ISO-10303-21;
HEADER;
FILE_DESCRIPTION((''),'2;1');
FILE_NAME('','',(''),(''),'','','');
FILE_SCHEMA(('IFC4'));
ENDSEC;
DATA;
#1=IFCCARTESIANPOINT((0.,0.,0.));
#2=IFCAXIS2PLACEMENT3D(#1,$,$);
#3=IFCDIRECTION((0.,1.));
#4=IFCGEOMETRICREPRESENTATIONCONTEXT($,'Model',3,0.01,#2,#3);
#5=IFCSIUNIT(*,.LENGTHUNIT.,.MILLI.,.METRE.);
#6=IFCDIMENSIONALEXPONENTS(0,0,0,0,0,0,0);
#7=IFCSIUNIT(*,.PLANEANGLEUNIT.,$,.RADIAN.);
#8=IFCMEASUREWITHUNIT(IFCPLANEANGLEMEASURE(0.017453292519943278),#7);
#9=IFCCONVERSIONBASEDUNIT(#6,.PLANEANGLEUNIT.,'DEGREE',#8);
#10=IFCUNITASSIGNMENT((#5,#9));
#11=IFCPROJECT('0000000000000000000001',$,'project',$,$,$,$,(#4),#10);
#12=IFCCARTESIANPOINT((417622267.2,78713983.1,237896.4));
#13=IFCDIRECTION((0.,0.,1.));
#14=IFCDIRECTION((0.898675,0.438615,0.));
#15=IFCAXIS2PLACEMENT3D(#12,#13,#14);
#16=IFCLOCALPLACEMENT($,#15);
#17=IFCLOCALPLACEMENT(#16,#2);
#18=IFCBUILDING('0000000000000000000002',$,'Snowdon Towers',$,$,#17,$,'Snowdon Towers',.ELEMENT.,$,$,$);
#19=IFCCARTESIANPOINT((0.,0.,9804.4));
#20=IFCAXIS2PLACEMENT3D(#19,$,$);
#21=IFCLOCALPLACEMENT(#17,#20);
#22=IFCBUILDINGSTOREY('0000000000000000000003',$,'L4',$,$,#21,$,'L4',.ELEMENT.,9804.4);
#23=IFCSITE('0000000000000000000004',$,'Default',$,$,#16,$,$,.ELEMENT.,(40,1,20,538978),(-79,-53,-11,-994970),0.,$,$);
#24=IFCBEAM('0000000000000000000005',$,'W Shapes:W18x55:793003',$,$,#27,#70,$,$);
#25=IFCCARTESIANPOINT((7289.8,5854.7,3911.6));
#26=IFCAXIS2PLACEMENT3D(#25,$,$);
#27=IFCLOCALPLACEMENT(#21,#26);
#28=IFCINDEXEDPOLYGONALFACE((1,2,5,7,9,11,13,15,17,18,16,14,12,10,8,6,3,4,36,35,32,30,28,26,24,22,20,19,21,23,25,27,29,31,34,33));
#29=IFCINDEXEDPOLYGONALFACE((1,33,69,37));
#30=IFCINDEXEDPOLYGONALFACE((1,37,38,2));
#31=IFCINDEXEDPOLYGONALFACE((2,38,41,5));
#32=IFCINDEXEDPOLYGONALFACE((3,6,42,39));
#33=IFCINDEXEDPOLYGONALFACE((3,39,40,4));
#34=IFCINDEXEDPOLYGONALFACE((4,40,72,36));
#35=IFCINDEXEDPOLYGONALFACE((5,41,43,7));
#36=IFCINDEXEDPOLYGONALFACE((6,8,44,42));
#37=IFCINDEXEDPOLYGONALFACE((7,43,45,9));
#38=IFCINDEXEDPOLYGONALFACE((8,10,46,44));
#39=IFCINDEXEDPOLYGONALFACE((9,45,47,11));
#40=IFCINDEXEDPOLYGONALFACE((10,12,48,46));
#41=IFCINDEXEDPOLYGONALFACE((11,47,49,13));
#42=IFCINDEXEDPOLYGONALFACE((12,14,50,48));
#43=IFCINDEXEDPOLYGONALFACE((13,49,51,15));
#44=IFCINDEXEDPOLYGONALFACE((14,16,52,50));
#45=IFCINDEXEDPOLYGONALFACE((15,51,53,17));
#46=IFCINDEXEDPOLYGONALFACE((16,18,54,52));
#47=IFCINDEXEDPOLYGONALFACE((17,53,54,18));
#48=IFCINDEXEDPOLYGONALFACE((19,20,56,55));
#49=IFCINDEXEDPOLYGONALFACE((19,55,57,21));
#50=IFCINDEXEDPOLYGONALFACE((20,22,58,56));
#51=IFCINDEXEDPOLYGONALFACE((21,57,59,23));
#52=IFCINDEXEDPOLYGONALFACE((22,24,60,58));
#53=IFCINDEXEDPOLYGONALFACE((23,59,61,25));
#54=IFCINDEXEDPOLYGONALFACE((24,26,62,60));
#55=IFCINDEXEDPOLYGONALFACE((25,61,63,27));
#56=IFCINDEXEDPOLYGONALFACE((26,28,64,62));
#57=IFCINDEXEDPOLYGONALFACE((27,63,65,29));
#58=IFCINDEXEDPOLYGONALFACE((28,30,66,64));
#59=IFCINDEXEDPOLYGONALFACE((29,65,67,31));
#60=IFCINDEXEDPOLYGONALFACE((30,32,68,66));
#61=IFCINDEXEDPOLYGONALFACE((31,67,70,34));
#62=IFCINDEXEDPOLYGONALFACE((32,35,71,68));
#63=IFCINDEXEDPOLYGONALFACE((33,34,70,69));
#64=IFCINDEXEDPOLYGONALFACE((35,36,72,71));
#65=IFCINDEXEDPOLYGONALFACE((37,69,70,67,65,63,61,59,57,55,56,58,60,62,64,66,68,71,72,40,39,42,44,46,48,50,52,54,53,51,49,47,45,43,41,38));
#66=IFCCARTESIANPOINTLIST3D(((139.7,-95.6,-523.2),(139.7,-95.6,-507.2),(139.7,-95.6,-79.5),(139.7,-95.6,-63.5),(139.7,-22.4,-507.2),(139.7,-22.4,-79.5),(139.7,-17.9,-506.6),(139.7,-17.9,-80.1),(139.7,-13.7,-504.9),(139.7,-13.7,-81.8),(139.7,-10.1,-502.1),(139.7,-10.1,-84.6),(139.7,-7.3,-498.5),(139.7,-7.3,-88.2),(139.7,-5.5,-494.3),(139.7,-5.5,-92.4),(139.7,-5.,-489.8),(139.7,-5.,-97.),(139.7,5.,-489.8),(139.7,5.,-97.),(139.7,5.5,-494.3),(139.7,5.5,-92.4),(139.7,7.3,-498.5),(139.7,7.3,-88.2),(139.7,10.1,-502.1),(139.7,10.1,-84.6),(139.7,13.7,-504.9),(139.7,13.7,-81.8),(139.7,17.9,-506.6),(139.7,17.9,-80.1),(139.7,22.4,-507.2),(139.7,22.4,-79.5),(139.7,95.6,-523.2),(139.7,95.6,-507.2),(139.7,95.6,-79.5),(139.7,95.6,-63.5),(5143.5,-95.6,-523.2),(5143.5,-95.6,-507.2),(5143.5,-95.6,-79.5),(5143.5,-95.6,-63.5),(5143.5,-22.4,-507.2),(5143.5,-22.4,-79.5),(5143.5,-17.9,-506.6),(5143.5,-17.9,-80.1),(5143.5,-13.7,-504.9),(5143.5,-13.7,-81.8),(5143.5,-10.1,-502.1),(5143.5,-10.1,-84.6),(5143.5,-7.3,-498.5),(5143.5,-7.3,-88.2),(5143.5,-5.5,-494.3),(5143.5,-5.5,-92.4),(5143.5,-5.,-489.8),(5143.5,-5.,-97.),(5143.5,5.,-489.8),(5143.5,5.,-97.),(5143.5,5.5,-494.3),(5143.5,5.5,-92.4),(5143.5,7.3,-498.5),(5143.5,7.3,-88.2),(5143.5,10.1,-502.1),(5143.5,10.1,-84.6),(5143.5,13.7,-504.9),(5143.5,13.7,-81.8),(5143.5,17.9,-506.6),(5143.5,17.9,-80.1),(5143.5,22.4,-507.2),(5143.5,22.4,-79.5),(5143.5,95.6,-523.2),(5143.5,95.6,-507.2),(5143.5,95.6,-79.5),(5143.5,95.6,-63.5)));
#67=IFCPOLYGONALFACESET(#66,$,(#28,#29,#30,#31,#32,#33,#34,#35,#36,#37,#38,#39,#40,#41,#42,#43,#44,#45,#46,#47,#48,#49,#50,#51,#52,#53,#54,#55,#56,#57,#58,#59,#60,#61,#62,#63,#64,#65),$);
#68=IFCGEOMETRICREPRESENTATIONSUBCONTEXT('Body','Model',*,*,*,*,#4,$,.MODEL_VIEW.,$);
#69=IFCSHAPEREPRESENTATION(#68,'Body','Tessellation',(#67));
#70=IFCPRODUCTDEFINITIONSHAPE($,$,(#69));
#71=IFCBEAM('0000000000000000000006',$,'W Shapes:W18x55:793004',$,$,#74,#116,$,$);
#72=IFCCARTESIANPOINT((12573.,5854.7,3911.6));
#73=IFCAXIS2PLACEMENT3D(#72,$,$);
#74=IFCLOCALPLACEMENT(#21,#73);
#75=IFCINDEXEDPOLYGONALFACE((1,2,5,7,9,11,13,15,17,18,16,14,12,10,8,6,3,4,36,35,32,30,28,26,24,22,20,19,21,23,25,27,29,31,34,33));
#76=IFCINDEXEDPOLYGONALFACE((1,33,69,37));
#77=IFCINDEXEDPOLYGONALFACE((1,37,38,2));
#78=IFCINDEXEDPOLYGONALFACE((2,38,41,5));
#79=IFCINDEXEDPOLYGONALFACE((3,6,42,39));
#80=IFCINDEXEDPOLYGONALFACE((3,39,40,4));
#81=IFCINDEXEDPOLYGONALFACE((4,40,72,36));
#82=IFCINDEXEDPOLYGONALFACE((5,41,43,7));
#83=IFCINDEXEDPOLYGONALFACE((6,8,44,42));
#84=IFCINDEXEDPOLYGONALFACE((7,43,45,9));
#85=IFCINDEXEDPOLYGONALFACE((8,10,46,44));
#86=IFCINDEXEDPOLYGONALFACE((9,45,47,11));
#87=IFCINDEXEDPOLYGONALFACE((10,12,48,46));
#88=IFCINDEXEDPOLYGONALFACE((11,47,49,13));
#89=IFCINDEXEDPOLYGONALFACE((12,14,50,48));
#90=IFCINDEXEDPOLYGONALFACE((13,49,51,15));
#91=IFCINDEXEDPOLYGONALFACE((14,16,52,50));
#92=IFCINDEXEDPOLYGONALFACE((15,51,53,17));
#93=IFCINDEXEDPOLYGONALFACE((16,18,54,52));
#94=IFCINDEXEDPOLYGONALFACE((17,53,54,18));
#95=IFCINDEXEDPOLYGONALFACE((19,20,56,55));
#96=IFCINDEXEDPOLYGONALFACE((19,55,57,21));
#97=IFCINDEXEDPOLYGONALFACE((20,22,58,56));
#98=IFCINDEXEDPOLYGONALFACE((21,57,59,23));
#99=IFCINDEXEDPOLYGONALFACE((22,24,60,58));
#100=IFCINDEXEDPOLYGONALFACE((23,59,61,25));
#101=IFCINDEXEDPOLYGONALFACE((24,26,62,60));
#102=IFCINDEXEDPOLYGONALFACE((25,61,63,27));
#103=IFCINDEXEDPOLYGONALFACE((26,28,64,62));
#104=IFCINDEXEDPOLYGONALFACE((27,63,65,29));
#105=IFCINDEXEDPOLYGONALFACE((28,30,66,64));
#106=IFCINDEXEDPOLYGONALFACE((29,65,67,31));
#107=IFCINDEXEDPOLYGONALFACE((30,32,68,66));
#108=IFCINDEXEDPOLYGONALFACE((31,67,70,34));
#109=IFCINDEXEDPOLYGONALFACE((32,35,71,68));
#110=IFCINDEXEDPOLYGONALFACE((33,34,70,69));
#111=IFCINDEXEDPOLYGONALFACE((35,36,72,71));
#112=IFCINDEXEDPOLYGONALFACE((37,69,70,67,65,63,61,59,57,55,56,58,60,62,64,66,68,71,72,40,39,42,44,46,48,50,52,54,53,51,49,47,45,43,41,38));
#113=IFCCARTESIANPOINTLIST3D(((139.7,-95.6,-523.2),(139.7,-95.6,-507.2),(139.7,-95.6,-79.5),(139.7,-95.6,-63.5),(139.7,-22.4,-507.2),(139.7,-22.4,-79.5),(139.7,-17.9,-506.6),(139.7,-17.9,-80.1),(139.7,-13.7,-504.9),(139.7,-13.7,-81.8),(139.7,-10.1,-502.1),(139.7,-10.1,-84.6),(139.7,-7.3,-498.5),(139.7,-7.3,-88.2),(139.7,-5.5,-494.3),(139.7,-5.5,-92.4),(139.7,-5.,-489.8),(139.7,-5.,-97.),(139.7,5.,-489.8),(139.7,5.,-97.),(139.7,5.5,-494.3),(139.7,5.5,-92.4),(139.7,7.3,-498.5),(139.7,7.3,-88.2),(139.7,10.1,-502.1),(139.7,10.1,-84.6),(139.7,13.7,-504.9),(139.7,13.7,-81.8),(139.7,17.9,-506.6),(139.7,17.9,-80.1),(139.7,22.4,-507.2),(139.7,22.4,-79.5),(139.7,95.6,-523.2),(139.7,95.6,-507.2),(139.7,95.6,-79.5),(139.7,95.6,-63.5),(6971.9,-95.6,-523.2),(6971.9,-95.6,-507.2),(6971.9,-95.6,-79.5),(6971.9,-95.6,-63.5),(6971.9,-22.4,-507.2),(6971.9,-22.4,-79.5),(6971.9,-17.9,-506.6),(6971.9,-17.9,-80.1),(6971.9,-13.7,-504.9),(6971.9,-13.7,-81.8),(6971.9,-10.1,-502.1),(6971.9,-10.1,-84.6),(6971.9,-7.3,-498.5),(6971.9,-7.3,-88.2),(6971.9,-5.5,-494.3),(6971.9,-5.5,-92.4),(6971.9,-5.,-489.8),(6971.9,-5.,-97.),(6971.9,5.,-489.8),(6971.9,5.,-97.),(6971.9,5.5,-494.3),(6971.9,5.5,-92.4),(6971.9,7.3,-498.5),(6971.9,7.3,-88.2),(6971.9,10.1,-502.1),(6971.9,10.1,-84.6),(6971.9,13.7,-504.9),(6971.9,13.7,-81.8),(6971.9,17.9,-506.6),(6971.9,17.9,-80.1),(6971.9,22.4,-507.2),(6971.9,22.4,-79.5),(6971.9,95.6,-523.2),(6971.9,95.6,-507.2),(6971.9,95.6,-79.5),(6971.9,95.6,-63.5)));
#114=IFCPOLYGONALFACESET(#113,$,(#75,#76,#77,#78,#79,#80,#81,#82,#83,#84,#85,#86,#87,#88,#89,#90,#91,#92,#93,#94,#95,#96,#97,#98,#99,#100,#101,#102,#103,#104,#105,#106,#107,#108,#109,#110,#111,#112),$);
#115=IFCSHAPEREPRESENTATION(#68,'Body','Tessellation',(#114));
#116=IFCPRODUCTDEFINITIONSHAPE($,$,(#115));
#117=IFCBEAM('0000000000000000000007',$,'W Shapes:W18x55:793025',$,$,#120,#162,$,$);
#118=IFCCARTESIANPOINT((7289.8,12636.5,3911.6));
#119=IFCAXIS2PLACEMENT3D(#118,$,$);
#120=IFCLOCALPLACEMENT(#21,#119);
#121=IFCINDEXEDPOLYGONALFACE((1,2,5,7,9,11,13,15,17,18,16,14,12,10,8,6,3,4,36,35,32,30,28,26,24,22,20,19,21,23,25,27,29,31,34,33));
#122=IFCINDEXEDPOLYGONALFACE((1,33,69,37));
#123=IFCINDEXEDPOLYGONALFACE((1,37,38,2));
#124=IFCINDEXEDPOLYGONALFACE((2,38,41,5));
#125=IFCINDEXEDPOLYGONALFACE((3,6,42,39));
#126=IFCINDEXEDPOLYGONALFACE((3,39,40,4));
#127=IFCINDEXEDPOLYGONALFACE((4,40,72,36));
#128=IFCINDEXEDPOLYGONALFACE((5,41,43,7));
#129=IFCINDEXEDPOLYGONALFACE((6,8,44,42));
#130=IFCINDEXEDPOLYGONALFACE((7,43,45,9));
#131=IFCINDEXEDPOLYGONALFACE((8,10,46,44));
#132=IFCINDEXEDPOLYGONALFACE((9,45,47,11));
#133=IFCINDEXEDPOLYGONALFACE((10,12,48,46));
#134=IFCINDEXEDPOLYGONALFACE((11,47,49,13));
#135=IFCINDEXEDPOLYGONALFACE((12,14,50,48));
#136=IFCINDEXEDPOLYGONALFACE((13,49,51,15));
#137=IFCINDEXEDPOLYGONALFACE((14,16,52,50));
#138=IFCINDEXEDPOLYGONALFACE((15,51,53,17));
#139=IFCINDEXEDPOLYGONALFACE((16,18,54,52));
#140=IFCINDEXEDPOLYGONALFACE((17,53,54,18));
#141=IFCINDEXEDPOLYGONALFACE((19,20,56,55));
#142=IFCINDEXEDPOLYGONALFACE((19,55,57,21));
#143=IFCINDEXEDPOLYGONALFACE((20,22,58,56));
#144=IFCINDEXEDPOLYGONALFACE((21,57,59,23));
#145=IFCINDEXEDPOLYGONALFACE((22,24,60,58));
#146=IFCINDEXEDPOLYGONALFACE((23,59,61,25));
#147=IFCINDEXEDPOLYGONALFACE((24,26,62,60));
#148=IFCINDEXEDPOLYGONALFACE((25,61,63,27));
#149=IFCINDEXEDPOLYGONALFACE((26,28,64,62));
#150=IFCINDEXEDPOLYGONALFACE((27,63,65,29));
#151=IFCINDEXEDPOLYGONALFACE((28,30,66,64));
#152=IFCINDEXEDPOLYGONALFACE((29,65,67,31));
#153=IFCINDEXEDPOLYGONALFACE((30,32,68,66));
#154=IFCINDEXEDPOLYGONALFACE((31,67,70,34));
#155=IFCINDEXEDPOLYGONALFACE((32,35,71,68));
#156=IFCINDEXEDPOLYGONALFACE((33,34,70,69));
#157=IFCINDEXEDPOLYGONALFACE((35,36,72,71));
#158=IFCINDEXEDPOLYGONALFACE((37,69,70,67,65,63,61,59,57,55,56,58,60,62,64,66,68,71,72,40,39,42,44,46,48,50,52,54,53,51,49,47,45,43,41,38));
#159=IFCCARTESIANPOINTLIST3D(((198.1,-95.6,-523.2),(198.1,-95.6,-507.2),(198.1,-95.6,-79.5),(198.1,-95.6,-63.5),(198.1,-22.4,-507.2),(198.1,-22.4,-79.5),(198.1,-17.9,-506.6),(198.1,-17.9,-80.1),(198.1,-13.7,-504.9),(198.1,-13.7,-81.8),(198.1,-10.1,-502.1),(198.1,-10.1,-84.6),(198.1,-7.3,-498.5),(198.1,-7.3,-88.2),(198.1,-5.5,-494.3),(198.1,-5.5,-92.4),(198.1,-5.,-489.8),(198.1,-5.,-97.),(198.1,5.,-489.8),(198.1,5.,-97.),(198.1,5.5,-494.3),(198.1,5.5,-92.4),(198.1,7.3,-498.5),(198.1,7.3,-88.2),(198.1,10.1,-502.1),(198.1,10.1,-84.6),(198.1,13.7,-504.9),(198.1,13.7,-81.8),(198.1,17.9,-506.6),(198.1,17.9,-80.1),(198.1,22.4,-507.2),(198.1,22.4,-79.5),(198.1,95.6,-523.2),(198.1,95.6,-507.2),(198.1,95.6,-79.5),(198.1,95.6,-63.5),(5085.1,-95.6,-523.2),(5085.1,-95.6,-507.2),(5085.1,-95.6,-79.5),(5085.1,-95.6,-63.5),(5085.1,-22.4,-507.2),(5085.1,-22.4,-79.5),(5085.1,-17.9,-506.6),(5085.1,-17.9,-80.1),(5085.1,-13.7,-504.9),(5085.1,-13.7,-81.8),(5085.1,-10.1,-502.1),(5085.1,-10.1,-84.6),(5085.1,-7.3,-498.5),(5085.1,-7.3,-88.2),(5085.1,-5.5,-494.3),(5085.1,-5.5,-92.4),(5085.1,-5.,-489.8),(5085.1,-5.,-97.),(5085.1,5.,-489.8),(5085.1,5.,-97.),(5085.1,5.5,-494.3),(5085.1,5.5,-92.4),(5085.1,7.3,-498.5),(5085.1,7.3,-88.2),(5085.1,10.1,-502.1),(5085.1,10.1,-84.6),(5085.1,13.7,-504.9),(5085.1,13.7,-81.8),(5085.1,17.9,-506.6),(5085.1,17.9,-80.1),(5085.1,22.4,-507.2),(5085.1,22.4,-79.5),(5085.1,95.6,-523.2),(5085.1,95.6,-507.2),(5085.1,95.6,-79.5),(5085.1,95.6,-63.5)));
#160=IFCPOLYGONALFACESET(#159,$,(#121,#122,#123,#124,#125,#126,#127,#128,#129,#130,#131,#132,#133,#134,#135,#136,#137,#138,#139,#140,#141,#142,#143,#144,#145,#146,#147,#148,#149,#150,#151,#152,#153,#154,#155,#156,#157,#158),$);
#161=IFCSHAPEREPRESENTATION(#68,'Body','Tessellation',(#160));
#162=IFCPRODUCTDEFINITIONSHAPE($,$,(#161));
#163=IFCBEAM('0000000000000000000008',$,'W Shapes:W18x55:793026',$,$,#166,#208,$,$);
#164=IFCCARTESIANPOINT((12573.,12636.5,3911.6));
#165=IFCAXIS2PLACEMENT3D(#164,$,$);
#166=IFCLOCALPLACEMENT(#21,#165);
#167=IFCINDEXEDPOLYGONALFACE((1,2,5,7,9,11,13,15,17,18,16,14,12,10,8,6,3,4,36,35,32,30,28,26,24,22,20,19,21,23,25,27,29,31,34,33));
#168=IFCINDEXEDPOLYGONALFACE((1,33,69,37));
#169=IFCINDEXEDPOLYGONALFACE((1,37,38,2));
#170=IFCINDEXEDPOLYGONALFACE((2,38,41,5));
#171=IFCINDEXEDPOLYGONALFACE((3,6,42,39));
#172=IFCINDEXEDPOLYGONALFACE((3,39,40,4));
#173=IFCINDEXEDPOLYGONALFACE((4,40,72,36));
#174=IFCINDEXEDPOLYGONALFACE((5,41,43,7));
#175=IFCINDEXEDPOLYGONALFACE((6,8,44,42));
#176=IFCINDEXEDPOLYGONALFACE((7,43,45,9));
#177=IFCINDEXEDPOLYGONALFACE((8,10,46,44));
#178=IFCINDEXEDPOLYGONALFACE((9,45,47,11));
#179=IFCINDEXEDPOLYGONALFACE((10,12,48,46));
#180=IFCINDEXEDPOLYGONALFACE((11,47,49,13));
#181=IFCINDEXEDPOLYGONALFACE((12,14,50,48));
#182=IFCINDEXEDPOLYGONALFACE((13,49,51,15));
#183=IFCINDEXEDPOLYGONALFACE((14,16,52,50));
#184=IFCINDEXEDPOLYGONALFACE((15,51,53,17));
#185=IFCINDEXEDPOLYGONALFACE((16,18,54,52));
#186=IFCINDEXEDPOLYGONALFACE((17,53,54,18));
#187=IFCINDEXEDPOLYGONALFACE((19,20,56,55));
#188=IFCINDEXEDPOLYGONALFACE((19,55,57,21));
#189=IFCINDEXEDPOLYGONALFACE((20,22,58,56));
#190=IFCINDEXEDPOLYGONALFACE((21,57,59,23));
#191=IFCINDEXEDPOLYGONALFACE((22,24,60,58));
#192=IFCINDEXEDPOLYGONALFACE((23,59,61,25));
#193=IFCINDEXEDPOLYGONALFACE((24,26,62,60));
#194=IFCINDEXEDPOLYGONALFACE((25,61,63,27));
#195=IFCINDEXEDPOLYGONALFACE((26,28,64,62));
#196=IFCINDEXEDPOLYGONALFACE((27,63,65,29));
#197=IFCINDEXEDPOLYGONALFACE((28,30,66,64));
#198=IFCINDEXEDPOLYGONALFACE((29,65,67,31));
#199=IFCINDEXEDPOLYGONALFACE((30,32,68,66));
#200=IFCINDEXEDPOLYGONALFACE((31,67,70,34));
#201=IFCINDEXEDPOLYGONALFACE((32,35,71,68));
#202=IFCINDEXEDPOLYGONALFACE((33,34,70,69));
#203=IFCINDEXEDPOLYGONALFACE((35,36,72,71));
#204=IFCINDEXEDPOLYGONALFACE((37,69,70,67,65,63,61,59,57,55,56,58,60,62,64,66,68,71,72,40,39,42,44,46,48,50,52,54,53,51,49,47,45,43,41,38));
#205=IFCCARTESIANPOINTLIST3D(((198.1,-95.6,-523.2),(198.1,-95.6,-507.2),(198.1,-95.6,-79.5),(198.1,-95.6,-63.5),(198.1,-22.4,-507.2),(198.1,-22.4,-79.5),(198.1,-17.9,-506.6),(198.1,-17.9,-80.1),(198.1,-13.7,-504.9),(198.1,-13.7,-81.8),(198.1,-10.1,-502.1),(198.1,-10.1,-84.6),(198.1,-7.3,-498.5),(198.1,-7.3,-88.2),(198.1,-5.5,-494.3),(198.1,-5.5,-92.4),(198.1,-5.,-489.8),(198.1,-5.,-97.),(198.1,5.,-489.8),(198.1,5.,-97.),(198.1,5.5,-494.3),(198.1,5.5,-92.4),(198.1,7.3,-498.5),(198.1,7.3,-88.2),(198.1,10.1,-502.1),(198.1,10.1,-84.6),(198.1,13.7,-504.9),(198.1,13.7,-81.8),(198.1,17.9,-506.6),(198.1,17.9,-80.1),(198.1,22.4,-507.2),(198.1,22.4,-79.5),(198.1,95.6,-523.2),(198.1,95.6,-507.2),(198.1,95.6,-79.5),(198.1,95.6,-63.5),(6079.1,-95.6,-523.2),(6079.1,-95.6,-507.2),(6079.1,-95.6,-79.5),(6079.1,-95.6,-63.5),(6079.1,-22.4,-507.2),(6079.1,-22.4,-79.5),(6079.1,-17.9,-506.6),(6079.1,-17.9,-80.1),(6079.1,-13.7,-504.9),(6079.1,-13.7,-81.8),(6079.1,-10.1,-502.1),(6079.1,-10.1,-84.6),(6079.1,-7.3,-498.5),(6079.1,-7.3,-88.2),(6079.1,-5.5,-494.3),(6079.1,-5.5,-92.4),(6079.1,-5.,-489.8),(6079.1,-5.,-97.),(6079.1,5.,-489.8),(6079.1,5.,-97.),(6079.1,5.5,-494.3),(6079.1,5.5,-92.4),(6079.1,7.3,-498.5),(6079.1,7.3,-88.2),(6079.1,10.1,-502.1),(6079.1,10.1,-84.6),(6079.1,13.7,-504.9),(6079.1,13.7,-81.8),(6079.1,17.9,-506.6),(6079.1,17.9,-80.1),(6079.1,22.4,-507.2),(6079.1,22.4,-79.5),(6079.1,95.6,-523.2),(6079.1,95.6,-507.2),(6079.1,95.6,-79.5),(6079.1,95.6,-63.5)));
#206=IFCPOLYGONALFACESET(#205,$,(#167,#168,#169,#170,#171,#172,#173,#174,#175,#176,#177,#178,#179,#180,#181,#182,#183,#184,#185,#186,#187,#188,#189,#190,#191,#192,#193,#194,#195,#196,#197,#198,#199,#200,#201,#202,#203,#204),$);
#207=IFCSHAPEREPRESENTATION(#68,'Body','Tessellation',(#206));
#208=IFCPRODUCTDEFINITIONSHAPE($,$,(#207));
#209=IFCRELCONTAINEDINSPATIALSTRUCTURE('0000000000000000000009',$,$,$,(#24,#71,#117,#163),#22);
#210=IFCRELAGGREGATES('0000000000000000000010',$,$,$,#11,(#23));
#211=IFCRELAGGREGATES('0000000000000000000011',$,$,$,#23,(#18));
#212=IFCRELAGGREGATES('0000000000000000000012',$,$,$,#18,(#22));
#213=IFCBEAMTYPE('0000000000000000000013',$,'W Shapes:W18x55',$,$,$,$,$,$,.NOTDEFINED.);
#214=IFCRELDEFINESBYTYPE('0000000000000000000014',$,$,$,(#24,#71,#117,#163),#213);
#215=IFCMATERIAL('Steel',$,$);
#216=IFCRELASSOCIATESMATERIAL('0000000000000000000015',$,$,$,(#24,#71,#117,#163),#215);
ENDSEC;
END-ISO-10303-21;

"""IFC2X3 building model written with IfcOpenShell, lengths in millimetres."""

from ifc_helpers import new_model, entity, si_unit, converted_unit, direction, frame, frame_2d, origin, place, context, subcontext, project, spatial, i_section, extrude, material, type_object, element, save


model = new_model("IFC2X3")

# Units and contexts
model_context = context("Model", 3, precision=0.01, world=origin(), true_north=direction((0.0, 1.0)))
body_context = subcontext(model_context, "Body", "Model", "MODEL_VIEW")
ifc_project = project(units=[si_unit("LENGTHUNIT", "METRE", prefix="MILLI"), converted_unit("PLANEANGLEUNIT", "DEGREE", entity("IfcPlaneAngleMeasure", 0.017453292519943278), si_unit("PLANEANGLEUNIT", "RADIAN"), dimensions=[0, 0, 0, 0, 0, 0, 0])], contexts=[model_context])

# Site, building, storey
site_placement = place(None, frame((417622267.2, 78713983.1, 237896.4), z_axis=(0.0, 0.0, 1.0), x_axis=(0.898675, 0.438615, 0.0)))
site = spatial("IfcSite", under=ifc_project, at=site_placement, Name="Default", CompositionType="ELEMENT", RefLatitude=(40, 1, 20, 538978), RefLongitude=(-79, -53, -11, -994970), RefElevation=0.0)
building_placement = place(site_placement, origin())
building = spatial("IfcBuilding", under=site, at=building_placement, Name="Snowdon Towers", LongName="Snowdon Towers", CompositionType="ELEMENT")
storey_placement = place(building_placement, frame((0.0, 0.0, 9804.4)))
storey = spatial("IfcBuildingStorey", under=building, at=storey_placement, Name="L4", LongName="L4", CompositionType="ELEMENT", Elevation=9804.4)

# Shared definitions
ifc_material_1 = material(Name="Steel")

# Beams
beam_type = type_object("IfcBeamType", Name="W Shapes:W18x55", PredefinedType="NOTDEFINED")
beam_1_placement = place(storey_placement, frame((7289.8, 5854.7, 3911.6)))
element("IfcBeam", 1, at=beam_1_placement, inside=storey, type_object=beam_type, material=ifc_material_1, Name="W Shapes:W18x55:793003", context=body_context, shape_type="SweptSolid", body=[
    extrude(i_section(OverallWidth=191.3, OverallDepth=459.7, WebThickness=9.9, FlangeThickness=16.0, FilletRadius=17.5, at=frame_2d((0.0, 0.0), x_axis=(0.0, 1.0))), frame((139.7, 0.0, -293.4), z_axis=(1.0, 0.0, 0.0), x_axis=(0.0, 0.0, -1.0)), (0.0, 0.0, 1.0), 5003.8),
])
beam_2_placement = place(storey_placement, frame((12573.0, 5854.7, 3911.6)))
element("IfcBeam", 2, at=beam_2_placement, inside=storey, type_object=beam_type, material=ifc_material_1, Name="W Shapes:W18x55:793004", context=body_context, shape_type="SweptSolid", body=[
    extrude(i_section(OverallWidth=191.3, OverallDepth=459.7, WebThickness=9.9, FlangeThickness=16.0, FilletRadius=17.5, at=frame_2d((0.0, 0.0), x_axis=(0.0, 1.0))), frame((139.7, 0.0, -293.4), z_axis=(1.0, 0.0, 0.0), x_axis=(0.0, 0.0, -1.0)), (0.0, 0.0, 1.0), 6832.2),
])
beam_3_placement = place(storey_placement, frame((7289.8, 12636.5, 3911.6)))
element("IfcBeam", 3, at=beam_3_placement, inside=storey, type_object=beam_type, material=ifc_material_1, Name="W Shapes:W18x55:793025", context=body_context, shape_type="SweptSolid", body=[
    extrude(i_section(OverallWidth=191.3, OverallDepth=459.7, WebThickness=9.9, FlangeThickness=16.0, FilletRadius=17.5, at=frame_2d((0.0, 0.0), x_axis=(0.0, 1.0))), frame((198.1, 0.0, -293.4), z_axis=(1.0, 0.0, 0.0), x_axis=(0.0, 0.0, -1.0)), (0.0, 0.0, 1.0), 4887.0),
])
beam_4_placement = place(storey_placement, frame((12573.0, 12636.5, 3911.6)))
element("IfcBeam", 4, at=beam_4_placement, inside=storey, type_object=beam_type, material=ifc_material_1, Name="W Shapes:W18x55:793026", context=body_context, shape_type="SweptSolid", body=[
    extrude(i_section(OverallWidth=191.3, OverallDepth=459.7, WebThickness=9.9, FlangeThickness=16.0, FilletRadius=17.5, at=frame_2d((0.0, 0.0), x_axis=(0.0, 1.0))), frame((198.1, 0.0, -293.4), z_axis=(1.0, 0.0, 0.0), x_axis=(0.0, 0.0, -1.0)), (0.0, 0.0, 1.0), 5881.0),
])

save(model, "model.ifc")
